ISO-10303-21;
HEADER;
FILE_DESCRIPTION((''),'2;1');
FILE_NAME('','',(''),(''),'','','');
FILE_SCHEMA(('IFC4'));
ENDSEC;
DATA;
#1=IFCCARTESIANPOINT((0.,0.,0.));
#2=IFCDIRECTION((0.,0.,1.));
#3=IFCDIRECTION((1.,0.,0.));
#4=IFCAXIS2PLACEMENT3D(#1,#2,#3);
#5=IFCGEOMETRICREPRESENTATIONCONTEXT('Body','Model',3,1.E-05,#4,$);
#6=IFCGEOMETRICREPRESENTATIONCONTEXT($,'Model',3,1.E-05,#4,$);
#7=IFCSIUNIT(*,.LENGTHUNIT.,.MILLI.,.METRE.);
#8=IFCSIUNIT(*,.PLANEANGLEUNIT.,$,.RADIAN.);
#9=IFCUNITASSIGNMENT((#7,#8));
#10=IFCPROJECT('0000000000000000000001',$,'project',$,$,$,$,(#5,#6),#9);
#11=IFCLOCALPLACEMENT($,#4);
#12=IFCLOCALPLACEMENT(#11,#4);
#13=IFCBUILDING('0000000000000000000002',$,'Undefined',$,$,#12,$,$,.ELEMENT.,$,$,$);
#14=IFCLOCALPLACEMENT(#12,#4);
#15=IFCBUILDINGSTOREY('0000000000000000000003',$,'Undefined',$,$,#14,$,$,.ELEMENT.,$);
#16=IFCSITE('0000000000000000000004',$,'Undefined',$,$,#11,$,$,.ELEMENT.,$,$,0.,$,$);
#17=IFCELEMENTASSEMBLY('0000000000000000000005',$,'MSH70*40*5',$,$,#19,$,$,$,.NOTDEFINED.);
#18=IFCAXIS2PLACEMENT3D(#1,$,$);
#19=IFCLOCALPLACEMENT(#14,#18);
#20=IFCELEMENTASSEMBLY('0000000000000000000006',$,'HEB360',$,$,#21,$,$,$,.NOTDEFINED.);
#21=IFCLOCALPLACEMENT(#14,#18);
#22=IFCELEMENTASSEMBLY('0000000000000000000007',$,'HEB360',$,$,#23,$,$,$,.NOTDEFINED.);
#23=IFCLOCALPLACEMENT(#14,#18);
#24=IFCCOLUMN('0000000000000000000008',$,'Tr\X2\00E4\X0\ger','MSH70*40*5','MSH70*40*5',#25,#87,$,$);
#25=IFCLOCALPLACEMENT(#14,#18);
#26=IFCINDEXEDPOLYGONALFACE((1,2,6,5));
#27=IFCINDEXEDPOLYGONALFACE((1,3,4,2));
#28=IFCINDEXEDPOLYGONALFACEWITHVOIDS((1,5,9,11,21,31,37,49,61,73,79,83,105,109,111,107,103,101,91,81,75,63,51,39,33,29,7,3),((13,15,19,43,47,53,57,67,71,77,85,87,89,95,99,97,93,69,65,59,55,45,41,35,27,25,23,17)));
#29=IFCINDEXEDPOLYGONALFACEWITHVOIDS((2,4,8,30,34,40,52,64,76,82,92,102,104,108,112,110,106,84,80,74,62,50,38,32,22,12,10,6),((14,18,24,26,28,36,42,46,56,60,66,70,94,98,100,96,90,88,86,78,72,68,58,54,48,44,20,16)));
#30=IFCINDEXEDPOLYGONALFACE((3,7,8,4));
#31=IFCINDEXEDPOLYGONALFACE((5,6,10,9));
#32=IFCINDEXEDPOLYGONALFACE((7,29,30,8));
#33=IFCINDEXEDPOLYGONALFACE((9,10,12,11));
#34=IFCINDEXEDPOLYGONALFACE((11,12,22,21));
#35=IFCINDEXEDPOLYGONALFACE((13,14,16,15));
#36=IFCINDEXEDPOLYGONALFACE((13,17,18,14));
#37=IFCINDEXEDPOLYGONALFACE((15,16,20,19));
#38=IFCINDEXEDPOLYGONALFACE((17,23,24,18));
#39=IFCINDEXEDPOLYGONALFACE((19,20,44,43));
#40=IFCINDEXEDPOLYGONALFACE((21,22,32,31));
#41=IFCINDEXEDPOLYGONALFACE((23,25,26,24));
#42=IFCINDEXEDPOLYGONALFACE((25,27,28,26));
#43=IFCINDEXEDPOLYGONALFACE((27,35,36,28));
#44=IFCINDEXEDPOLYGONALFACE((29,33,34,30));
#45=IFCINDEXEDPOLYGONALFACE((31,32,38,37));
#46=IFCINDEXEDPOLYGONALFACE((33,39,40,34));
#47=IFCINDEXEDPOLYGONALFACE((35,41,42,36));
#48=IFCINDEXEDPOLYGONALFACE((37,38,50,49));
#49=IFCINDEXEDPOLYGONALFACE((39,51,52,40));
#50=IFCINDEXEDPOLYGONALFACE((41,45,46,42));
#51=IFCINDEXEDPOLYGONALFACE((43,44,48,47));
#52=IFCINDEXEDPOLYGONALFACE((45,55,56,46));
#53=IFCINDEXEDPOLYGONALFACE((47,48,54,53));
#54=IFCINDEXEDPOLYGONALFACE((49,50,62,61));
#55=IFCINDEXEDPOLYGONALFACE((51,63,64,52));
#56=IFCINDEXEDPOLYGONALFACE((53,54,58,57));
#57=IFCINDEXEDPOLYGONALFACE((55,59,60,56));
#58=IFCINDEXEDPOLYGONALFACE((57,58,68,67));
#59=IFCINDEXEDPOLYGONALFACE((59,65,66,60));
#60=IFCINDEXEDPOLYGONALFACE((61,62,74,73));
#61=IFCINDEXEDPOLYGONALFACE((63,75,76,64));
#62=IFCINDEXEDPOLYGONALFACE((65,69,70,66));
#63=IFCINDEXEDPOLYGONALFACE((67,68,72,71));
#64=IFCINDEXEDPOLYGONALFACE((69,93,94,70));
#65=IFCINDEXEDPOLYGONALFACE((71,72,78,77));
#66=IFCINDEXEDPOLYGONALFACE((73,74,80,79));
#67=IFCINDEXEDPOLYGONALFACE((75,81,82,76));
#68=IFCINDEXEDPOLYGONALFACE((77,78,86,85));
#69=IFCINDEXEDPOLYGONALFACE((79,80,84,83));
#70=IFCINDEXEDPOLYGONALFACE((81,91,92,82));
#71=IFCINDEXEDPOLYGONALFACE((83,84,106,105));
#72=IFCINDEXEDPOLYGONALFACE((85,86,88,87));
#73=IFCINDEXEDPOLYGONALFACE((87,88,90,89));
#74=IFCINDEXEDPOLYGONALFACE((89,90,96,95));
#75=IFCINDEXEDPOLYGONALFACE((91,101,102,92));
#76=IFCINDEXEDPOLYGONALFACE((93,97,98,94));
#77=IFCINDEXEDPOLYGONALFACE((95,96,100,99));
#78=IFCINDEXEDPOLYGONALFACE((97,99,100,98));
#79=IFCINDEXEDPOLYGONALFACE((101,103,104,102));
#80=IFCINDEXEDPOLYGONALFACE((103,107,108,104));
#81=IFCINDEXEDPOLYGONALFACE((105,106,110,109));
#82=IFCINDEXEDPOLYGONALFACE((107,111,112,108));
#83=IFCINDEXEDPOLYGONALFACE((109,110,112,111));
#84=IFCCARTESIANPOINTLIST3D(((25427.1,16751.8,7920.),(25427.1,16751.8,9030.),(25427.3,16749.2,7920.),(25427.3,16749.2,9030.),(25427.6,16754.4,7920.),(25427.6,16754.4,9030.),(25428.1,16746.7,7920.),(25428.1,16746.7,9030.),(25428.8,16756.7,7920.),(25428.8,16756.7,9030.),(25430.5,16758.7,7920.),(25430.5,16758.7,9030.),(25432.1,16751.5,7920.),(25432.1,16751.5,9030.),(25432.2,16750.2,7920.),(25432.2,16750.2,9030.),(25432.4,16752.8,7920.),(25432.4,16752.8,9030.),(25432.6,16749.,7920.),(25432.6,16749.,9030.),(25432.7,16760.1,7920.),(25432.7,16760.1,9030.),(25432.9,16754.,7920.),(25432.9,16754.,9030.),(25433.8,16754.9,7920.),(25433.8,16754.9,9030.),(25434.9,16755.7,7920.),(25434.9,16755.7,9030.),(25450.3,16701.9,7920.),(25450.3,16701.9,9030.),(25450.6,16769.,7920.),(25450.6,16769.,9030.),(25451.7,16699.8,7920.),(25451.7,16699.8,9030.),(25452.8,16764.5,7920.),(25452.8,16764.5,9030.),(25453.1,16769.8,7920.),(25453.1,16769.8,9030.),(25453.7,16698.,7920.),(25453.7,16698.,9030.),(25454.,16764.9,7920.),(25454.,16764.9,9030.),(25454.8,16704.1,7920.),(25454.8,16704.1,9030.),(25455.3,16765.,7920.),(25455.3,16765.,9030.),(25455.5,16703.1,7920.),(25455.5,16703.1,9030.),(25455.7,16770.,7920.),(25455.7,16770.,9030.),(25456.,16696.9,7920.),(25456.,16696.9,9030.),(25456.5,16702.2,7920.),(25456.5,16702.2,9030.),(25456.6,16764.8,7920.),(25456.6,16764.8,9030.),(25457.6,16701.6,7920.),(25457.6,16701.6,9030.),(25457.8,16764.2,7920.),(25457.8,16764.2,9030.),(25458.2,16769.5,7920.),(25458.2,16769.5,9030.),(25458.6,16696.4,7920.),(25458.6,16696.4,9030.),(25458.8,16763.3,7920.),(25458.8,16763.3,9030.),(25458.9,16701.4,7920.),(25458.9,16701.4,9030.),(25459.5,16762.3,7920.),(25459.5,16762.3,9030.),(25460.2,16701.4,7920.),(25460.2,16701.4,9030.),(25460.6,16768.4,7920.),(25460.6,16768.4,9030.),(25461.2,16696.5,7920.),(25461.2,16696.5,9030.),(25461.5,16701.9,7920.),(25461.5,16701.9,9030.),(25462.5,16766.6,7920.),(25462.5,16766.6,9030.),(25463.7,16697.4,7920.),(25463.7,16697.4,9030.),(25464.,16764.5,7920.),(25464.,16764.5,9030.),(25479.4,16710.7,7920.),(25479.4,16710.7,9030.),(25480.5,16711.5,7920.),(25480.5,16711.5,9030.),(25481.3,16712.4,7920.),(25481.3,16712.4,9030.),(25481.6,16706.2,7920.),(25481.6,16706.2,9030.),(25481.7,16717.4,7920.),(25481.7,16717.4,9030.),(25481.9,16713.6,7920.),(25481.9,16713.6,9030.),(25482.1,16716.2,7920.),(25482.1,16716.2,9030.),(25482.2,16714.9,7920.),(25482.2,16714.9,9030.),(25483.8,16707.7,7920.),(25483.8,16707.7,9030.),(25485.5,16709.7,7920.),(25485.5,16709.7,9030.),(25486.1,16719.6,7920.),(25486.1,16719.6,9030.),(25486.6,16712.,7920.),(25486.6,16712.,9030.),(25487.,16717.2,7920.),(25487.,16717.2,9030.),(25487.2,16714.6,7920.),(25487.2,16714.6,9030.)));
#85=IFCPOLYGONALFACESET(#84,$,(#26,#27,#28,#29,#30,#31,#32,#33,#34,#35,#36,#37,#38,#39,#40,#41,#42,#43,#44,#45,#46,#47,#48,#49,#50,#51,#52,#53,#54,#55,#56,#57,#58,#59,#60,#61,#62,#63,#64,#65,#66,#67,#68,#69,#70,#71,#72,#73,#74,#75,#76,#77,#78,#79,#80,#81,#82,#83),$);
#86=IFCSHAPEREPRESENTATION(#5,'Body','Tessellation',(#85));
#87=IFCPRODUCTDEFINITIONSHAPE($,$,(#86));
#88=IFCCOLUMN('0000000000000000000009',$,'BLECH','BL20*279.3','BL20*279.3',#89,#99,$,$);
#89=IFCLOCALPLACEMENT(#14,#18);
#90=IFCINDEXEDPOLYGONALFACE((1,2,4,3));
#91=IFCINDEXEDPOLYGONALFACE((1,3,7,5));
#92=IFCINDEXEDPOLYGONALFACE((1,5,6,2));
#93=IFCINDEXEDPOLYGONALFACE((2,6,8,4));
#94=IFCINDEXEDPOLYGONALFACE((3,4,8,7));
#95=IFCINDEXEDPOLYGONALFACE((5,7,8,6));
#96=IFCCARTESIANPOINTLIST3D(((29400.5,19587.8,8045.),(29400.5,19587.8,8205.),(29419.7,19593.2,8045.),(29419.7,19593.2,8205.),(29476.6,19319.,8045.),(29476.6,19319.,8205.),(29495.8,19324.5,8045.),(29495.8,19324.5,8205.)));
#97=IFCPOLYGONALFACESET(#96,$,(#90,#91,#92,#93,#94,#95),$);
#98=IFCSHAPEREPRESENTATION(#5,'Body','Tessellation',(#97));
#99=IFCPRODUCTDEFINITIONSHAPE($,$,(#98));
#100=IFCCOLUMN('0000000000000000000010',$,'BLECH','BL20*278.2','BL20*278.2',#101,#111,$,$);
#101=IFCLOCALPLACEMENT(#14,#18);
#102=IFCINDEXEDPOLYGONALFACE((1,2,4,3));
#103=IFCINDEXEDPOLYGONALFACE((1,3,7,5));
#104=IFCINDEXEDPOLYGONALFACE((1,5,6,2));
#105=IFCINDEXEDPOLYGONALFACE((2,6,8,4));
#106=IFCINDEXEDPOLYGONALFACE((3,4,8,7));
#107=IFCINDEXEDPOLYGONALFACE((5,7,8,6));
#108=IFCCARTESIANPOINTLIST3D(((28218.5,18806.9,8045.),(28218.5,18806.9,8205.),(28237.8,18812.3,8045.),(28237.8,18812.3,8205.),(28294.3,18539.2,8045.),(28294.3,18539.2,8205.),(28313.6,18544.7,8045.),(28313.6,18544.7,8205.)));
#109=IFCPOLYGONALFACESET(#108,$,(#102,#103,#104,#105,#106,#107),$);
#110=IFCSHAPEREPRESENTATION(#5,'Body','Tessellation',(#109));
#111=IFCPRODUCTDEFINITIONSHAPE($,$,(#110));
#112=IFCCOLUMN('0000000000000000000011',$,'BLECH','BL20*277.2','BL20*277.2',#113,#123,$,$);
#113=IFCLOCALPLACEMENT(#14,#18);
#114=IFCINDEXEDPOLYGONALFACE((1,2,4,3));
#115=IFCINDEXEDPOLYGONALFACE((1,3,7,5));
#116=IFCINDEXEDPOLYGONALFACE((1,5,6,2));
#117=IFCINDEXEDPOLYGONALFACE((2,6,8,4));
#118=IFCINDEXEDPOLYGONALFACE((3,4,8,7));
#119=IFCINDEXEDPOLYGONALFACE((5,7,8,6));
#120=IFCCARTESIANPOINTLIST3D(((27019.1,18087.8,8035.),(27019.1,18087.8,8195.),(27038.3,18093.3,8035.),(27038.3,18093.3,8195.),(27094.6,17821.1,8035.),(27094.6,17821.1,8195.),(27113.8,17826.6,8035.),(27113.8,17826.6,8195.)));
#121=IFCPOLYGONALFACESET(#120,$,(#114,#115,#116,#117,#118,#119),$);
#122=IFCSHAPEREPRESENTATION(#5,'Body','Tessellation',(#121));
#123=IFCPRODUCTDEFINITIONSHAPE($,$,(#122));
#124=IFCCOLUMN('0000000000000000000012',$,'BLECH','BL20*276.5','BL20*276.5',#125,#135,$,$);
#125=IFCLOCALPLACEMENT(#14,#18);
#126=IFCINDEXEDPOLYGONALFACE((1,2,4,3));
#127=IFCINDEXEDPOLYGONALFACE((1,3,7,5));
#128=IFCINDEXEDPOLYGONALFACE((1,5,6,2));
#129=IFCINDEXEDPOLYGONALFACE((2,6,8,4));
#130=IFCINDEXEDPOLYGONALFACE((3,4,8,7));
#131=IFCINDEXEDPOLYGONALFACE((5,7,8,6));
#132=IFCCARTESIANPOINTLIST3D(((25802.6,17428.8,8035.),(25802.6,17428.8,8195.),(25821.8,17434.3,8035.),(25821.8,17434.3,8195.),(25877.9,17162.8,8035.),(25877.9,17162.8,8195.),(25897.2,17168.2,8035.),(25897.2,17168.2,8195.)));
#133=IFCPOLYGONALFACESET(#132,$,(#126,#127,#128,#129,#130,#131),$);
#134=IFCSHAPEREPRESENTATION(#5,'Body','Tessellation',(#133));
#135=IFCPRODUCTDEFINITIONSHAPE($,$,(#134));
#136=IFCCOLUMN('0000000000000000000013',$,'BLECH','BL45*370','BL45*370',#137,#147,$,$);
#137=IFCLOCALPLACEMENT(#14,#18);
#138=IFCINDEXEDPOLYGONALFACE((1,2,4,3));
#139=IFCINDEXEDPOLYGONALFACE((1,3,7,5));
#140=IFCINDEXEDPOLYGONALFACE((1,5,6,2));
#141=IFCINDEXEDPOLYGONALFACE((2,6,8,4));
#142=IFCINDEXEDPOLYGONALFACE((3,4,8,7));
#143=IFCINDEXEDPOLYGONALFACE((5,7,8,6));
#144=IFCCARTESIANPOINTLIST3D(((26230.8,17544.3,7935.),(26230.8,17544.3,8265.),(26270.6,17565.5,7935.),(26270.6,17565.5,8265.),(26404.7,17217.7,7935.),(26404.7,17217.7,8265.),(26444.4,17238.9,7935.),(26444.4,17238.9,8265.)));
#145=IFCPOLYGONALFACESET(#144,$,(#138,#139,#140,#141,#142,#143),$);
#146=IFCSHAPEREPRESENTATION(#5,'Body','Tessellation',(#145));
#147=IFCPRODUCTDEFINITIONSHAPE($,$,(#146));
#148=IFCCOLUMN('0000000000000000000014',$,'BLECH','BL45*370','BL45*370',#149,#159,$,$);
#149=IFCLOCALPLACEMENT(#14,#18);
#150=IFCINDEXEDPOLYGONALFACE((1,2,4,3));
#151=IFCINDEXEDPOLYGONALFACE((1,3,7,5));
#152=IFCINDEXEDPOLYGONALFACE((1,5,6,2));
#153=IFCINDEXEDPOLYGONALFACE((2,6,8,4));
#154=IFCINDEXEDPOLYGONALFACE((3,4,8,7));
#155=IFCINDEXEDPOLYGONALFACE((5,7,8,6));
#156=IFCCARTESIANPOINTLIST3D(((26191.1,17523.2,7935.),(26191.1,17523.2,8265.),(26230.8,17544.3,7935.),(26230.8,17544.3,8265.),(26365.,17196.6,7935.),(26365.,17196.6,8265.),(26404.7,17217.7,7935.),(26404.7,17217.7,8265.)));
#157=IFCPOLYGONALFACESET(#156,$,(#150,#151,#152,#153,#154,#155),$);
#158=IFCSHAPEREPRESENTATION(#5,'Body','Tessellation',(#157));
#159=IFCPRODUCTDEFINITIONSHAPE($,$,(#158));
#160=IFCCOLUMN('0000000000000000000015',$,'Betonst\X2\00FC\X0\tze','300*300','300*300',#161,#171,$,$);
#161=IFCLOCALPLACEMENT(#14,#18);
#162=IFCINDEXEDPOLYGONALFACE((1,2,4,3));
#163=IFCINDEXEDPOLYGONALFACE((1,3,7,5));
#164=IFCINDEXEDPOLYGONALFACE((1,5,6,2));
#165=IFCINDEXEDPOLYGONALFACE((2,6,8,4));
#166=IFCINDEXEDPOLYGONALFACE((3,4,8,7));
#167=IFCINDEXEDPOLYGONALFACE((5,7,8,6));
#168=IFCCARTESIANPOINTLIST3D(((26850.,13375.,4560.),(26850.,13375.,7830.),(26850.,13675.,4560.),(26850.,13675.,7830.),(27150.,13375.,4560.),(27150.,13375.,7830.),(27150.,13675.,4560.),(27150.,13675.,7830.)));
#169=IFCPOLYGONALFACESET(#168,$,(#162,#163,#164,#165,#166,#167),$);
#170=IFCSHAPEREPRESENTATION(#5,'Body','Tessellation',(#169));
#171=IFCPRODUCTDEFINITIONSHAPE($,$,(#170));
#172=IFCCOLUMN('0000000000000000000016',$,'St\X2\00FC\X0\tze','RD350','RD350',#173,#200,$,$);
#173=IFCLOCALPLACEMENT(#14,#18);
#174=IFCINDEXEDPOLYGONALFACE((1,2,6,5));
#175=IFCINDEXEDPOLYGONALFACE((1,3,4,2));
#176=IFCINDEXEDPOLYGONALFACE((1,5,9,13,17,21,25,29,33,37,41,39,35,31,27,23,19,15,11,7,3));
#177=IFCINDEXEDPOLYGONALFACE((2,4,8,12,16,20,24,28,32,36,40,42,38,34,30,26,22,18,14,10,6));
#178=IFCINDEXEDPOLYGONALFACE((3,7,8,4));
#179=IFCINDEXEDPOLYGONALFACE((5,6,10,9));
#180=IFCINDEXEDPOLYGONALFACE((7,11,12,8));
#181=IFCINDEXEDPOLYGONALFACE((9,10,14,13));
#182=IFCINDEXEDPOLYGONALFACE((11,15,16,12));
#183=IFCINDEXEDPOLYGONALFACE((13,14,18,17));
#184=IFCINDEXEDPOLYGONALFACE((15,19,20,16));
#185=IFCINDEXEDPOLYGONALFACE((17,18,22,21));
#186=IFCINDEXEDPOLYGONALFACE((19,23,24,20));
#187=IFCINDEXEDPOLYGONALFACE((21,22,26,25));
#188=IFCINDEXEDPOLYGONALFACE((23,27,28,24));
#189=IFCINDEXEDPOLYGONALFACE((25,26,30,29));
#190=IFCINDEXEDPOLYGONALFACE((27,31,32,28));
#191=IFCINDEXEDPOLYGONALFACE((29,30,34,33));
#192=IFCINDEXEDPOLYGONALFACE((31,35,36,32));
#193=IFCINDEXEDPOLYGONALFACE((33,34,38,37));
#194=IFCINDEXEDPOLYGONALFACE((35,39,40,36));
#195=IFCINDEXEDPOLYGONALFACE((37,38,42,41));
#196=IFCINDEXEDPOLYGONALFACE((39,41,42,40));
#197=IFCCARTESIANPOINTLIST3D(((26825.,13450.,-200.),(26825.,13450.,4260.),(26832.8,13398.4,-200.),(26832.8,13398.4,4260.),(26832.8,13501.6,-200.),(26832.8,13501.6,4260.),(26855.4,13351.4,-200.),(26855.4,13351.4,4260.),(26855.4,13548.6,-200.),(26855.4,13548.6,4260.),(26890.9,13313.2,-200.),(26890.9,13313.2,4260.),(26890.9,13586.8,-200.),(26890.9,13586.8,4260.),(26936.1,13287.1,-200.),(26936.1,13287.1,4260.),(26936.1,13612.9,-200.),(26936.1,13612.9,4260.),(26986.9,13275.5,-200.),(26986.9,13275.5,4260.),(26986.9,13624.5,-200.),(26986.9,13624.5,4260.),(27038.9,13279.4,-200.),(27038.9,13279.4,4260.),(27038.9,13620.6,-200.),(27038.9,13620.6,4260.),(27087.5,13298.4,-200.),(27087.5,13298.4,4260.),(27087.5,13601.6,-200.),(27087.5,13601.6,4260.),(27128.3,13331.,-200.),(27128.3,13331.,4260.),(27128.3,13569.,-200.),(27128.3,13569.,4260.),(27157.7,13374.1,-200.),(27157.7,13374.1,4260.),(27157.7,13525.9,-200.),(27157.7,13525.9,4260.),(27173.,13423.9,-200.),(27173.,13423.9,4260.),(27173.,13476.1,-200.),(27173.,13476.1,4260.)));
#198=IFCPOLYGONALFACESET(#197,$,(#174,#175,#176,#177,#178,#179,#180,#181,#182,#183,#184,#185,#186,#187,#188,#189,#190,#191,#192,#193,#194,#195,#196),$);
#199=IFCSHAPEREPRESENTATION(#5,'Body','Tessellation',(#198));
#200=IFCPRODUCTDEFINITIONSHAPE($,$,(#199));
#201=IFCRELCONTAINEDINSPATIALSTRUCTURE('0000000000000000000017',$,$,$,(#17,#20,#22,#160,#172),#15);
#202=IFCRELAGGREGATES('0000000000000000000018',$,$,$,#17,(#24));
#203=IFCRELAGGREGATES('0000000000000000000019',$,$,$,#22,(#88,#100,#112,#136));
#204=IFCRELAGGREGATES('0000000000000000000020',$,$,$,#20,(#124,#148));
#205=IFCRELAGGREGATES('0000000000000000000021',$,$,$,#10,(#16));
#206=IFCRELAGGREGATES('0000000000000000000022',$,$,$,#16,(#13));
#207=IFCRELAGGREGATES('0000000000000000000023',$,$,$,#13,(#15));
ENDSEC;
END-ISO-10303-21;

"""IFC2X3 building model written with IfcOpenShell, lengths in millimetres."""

from ifc_helpers import new_model, si_unit, frame, origin_with_axes, origin_2d_with_axis, place, context, project, spatial, rectangle, hollow_rectangle, circle, extrude, element, aggregate, save


model = new_model("IFC2X3")

# Units and contexts
model_context_1 = context("Model", 3, precision=1e-05, world=origin_with_axes(), identifier="Body")
model_context_2 = context("Model", 3, precision=1e-05, world=origin_with_axes())
ifc_project = project(units=[si_unit("LENGTHUNIT", "METRE", prefix="MILLI"), si_unit("PLANEANGLEUNIT", "RADIAN")], contexts=[model_context_1, model_context_2])

# Site, building, storey
site_placement = place(None, origin_with_axes())
site = spatial("IfcSite", under=ifc_project, at=site_placement, Name="Undefined", CompositionType="ELEMENT", RefElevation=0.0)
building_placement = place(site_placement, origin_with_axes())
building = spatial("IfcBuilding", under=site, at=building_placement, Name="Undefined", CompositionType="ELEMENT")
storey_placement = place(building_placement, origin_with_axes())
storey = spatial("IfcBuildingStorey", under=building, at=storey_placement, Name="Undefined", CompositionType="ELEMENT")

# Element assembly
assembly_1 = element("IfcElementAssembly", 1, inside=storey, Name="MSH70*40*5", PredefinedType="NOTDEFINED")

# Element assembly
assembly_2 = element("IfcElementAssembly", 2, inside=storey, Name="HEB360", PredefinedType="NOTDEFINED")

# Element assembly
assembly_3 = element("IfcElementAssembly", 3, inside=storey, Name="HEB360", PredefinedType="NOTDEFINED")

# Columns
column_1_placement = place(storey_placement, frame((25457.1, 16733.2, 7920.0), z_axis=(0.0, 0.0, 1.0), x_axis=(1.0, 0.0, 0.0)))
column_1 = element("IfcColumn", 4, at=column_1_placement, Name="Träger", Description="MSH70*40*5", ObjectType="MSH70*40*5", context=model_context_1, shape_type="SweptSolid", body=[
    extrude(hollow_rectangle(XDim=40.0, YDim=70.0, WallThickness=5.0, InnerFilletRadius=5.0, OuterFilletRadius=10.0, at=origin_2d_with_axis()), frame((0.0, 0.0, 1110.0), z_axis=(0.0, 0.0, -1.0), x_axis=(-0.896486, -0.443072, 0.000005)), (0.0, 0.0, 1.0), 1110.0),
])
aggregate(assembly_1, [column_1])
column_2_placement = place(storey_placement, frame((29448.2, 19456.1, 8045.0), z_axis=(0.0, 0.0, 1.0), x_axis=(1.0, 0.0, 0.0)))
column_2 = element("IfcColumn", 5, at=column_2_placement, Name="BLECH", Description="BL20*279.3", ObjectType="BL20*279.3", context=model_context_1, shape_type="SweptSolid", body=[
    extrude(rectangle(XDim=20.0, YDim=279.3, at=origin_2d_with_axis()), frame((0.0, 0.0, 160.0), z_axis=(0.0, 0.0, -1.0), x_axis=(0.96217, 0.272448, 0.0)), (0.0, 0.0, 1.0), 160.0),
])
column_3_placement = place(storey_placement, frame((28266.1, 18675.8, 8045.0), z_axis=(0.0, 0.0, 1.0), x_axis=(1.0, 0.0, 0.0)))
column_3 = element("IfcColumn", 6, at=column_3_placement, Name="BLECH", Description="BL20*278.2", ObjectType="BL20*278.2", context=model_context_1, shape_type="SweptSolid", body=[
    extrude(rectangle(XDim=20.0, YDim=278.2, at=origin_2d_with_axis()), frame((0.0, 0.0, 160.0), z_axis=(0.0, 0.0, -1.0), x_axis=(0.96217, 0.272448, 0.0)), (0.0, 0.0, 1.0), 160.0),
])
column_4_placement = place(storey_placement, frame((27066.5, 17957.2, 8035.0), z_axis=(0.0, 0.0, 1.0), x_axis=(1.0, 0.0, 0.0)))
column_4 = element("IfcColumn", 7, at=column_4_placement, Name="BLECH", Description="BL20*277.2", ObjectType="BL20*277.2", context=model_context_1, shape_type="SweptSolid", body=[
    extrude(rectangle(XDim=20.0, YDim=277.2, at=origin_2d_with_axis()), frame((0.0, 0.0, 160.0), z_axis=(0.0, 0.0, -1.0), x_axis=(0.96217, 0.272448, 0.0)), (0.0, 0.0, 1.0), 160.0),
])
column_5_placement = place(storey_placement, frame((25849.9, 17298.5, 8035.0), z_axis=(0.0, 0.0, 1.0), x_axis=(1.0, 0.0, 0.0)))
column_5 = element("IfcColumn", 8, at=column_5_placement, Name="BLECH", Description="BL20*276.5", ObjectType="BL20*276.5", context=model_context_1, shape_type="SweptSolid", body=[
    extrude(rectangle(XDim=20.0, YDim=276.5, at=origin_2d_with_axis()), frame((0.0, 0.0, 160.0), z_axis=(0.0, 0.0, -1.0), x_axis=(0.96217, 0.272448, 0.0)), (0.0, 0.0, 1.0), 160.0),
])
column_6_placement = place(storey_placement, frame((26337.6, 17391.6, 7935.0), z_axis=(0.0, 0.0, 1.0), x_axis=(1.0, 0.0, 0.0)))
column_6 = element("IfcColumn", 9, at=column_6_placement, Name="BLECH", Description="BL45*370", ObjectType="BL45*370", context=model_context_1, shape_type="SweptSolid", body=[
    extrude(rectangle(XDim=45.0, YDim=370.0, at=origin_2d_with_axis()), frame((0.0, 0.0, 330.0), z_axis=(0.0, 0.0, -1.0), x_axis=(0.882725, 0.469891, 0.0)), (0.0, 0.0, 1.0), 330.0),
])
aggregate(assembly_3, [column_2, column_3, column_4, column_6])
column_7_placement = place(storey_placement, frame((26297.9, 17370.4, 7935.0), z_axis=(0.0, 0.0, 1.0), x_axis=(1.0, 0.0, 0.0)))
column_7 = element("IfcColumn", 10, at=column_7_placement, Name="BLECH", Description="BL45*370", ObjectType="BL45*370", context=model_context_1, shape_type="SweptSolid", body=[
    extrude(rectangle(XDim=45.0, YDim=370.0, at=origin_2d_with_axis()), frame((0.0, 0.0, 330.0), z_axis=(0.0, 0.0, -1.0), x_axis=(0.882725, 0.469891, 0.0)), (0.0, 0.0, 1.0), 330.0),
])
aggregate(assembly_2, [column_5, column_7])

# Columns
column_8_placement = place(storey_placement, frame((27000.0, 13525.0, 4560.0), z_axis=(0.0, 0.0, 1.0), x_axis=(1.0, 0.0, 0.0)))
element("IfcColumn", 11, at=column_8_placement, inside=storey, Name="Betonstütze", Description="300*300", ObjectType="300*300", context=model_context_1, shape_type="SweptSolid", body=[
    extrude(rectangle(XDim=300.0, YDim=300.0, at=origin_2d_with_axis()), frame((0.0, 0.0, 3270.0), z_axis=(0.0, 0.0, -1.0), x_axis=(1.0, 0.0, 0.0)), (0.0, 0.0, 1.0), 3270.0),
])
column_9_placement = place(storey_placement, frame((27000.0, 13450.0, -200.0), z_axis=(0.0, 0.0, 1.0), x_axis=(1.0, 0.0, 0.0)))
element("IfcColumn", 12, at=column_9_placement, inside=storey, Name="Stütze", Description="RD350", ObjectType="RD350", context=model_context_1, shape_type="SweptSolid", body=[
    extrude(circle(Radius=175.0, at=origin_2d_with_axis()), frame((0.0, 0.0, 4460.0), z_axis=(0.0, 0.0, -1.0), x_axis=(-1.0, 0.0, 0.0)), (0.0, 0.0, 1.0), 4460.0),
])

save(model, "model.ifc")
